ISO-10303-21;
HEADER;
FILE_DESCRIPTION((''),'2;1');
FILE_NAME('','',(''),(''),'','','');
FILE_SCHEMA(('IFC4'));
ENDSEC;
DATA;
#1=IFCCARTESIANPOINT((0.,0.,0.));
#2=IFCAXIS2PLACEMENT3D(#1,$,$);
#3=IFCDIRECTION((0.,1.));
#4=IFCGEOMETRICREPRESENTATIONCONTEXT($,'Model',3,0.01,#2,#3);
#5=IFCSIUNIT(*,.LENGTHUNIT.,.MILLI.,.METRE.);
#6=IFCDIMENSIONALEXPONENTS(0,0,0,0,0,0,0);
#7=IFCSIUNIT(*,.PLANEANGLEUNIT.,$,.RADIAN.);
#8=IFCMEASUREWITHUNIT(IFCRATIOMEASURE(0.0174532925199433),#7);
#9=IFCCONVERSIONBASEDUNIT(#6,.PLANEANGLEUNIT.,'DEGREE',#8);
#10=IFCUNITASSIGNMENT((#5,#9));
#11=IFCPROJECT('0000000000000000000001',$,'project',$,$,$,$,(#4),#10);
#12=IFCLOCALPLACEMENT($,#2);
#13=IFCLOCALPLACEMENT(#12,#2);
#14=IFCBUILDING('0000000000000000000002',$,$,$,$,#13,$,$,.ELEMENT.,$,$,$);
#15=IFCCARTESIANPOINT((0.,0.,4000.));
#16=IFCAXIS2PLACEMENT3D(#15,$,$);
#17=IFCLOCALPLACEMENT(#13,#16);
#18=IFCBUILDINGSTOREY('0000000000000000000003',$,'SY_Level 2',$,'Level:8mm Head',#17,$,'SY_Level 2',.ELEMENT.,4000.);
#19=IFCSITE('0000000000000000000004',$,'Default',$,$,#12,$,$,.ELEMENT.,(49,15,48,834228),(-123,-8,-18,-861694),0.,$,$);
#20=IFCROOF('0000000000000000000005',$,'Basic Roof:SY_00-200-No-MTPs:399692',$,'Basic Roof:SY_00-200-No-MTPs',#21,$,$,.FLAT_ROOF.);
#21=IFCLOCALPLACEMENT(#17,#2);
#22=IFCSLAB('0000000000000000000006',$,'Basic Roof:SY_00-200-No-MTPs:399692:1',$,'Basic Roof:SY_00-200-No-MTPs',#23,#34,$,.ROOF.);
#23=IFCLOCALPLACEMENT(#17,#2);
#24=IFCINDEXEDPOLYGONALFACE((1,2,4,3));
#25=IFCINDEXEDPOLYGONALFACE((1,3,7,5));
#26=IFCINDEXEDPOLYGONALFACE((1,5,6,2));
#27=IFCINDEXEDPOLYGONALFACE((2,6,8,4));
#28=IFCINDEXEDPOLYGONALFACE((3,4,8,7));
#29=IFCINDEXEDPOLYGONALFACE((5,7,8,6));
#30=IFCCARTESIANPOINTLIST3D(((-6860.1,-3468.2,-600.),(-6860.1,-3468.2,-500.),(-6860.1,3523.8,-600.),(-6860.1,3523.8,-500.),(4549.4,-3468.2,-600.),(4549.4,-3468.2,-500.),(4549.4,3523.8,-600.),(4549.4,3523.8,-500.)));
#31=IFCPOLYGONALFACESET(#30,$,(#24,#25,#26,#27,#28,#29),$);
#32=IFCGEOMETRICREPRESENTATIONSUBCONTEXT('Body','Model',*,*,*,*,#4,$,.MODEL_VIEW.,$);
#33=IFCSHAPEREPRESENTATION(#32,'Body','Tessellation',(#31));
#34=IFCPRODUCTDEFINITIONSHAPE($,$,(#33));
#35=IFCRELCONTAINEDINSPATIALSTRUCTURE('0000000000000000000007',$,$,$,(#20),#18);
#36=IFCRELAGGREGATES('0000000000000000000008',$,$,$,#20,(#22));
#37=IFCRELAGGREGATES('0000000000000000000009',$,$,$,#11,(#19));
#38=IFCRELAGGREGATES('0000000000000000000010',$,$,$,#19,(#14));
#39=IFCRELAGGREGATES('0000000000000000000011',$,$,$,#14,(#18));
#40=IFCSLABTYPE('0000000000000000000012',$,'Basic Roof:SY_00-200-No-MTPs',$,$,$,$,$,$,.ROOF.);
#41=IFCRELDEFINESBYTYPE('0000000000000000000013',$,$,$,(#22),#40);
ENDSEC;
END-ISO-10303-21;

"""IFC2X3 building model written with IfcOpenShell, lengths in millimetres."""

from ifc_helpers import new_model, entity, si_unit, converted_unit, direction, frame, origin, origin_2d_with_axis, place, context, subcontext, project, spatial, rectangle, extrude, type_object, element, aggregate, save


model = new_model("IFC2X3")

# Units and contexts
model_context = context("Model", 3, precision=0.01, world=origin(), true_north=direction((0.0, 1.0)))
body_context = subcontext(model_context, "Body", "Model", "MODEL_VIEW")
ifc_project = project(units=[si_unit("LENGTHUNIT", "METRE", prefix="MILLI"), converted_unit("PLANEANGLEUNIT", "DEGREE", entity("IfcRatioMeasure", 0.0174532925199433), si_unit("PLANEANGLEUNIT", "RADIAN"), dimensions=[0, 0, 0, 0, 0, 0, 0])], contexts=[model_context])

# Site, building, storey
site_placement = place(None, origin())
site = spatial("IfcSite", under=ifc_project, at=site_placement, Name="Default", CompositionType="ELEMENT", RefLatitude=(49, 15, 48, 834228), RefLongitude=(-123, -8, -18, -861694), RefElevation=0.0)
building_placement = place(site_placement, origin())
building = spatial("IfcBuilding", under=site, at=building_placement, CompositionType="ELEMENT")
storey_placement = place(building_placement, frame((0.0, 0.0, 4000.0)))
storey = spatial("IfcBuildingStorey", under=building, at=storey_placement, Name="SY_Level 2", ObjectType="Level:8mm Head", LongName="SY_Level 2", CompositionType="ELEMENT", Elevation=4000.0)

# Roof, slab
roof_placement = place(storey_placement, origin())
roof = element("IfcRoof", 1, at=roof_placement, inside=storey, Name="Basic Roof:SY_00-200-No-MTPs:399692", ObjectType="Basic Roof:SY_00-200-No-MTPs", ShapeType="FLAT_ROOF")
slab_type = type_object("IfcSlabType", Name="Basic Roof:SY_00-200-No-MTPs", PredefinedType="ROOF")
slab_placement = place(storey_placement, origin())
slab = element("IfcSlab", 2, at=slab_placement, type_object=slab_type, Name="Basic Roof:SY_00-200-No-MTPs:399692:1", ObjectType="Basic Roof:SY_00-200-No-MTPs", PredefinedType="ROOF", context=body_context, shape_type="SweptSolid", body=[
    extrude(rectangle(XDim=11409.5, YDim=6992.0, at=origin_2d_with_axis()), frame((-1155.4, 27.8, -600.0), z_axis=(0.0, 0.0, 1.0), x_axis=(-1.0, 0.0, 0.0)), (0.0, 0.0, 1.0), 100.0),
])
aggregate(roof, [slab])

save(model, "model.ifc")
